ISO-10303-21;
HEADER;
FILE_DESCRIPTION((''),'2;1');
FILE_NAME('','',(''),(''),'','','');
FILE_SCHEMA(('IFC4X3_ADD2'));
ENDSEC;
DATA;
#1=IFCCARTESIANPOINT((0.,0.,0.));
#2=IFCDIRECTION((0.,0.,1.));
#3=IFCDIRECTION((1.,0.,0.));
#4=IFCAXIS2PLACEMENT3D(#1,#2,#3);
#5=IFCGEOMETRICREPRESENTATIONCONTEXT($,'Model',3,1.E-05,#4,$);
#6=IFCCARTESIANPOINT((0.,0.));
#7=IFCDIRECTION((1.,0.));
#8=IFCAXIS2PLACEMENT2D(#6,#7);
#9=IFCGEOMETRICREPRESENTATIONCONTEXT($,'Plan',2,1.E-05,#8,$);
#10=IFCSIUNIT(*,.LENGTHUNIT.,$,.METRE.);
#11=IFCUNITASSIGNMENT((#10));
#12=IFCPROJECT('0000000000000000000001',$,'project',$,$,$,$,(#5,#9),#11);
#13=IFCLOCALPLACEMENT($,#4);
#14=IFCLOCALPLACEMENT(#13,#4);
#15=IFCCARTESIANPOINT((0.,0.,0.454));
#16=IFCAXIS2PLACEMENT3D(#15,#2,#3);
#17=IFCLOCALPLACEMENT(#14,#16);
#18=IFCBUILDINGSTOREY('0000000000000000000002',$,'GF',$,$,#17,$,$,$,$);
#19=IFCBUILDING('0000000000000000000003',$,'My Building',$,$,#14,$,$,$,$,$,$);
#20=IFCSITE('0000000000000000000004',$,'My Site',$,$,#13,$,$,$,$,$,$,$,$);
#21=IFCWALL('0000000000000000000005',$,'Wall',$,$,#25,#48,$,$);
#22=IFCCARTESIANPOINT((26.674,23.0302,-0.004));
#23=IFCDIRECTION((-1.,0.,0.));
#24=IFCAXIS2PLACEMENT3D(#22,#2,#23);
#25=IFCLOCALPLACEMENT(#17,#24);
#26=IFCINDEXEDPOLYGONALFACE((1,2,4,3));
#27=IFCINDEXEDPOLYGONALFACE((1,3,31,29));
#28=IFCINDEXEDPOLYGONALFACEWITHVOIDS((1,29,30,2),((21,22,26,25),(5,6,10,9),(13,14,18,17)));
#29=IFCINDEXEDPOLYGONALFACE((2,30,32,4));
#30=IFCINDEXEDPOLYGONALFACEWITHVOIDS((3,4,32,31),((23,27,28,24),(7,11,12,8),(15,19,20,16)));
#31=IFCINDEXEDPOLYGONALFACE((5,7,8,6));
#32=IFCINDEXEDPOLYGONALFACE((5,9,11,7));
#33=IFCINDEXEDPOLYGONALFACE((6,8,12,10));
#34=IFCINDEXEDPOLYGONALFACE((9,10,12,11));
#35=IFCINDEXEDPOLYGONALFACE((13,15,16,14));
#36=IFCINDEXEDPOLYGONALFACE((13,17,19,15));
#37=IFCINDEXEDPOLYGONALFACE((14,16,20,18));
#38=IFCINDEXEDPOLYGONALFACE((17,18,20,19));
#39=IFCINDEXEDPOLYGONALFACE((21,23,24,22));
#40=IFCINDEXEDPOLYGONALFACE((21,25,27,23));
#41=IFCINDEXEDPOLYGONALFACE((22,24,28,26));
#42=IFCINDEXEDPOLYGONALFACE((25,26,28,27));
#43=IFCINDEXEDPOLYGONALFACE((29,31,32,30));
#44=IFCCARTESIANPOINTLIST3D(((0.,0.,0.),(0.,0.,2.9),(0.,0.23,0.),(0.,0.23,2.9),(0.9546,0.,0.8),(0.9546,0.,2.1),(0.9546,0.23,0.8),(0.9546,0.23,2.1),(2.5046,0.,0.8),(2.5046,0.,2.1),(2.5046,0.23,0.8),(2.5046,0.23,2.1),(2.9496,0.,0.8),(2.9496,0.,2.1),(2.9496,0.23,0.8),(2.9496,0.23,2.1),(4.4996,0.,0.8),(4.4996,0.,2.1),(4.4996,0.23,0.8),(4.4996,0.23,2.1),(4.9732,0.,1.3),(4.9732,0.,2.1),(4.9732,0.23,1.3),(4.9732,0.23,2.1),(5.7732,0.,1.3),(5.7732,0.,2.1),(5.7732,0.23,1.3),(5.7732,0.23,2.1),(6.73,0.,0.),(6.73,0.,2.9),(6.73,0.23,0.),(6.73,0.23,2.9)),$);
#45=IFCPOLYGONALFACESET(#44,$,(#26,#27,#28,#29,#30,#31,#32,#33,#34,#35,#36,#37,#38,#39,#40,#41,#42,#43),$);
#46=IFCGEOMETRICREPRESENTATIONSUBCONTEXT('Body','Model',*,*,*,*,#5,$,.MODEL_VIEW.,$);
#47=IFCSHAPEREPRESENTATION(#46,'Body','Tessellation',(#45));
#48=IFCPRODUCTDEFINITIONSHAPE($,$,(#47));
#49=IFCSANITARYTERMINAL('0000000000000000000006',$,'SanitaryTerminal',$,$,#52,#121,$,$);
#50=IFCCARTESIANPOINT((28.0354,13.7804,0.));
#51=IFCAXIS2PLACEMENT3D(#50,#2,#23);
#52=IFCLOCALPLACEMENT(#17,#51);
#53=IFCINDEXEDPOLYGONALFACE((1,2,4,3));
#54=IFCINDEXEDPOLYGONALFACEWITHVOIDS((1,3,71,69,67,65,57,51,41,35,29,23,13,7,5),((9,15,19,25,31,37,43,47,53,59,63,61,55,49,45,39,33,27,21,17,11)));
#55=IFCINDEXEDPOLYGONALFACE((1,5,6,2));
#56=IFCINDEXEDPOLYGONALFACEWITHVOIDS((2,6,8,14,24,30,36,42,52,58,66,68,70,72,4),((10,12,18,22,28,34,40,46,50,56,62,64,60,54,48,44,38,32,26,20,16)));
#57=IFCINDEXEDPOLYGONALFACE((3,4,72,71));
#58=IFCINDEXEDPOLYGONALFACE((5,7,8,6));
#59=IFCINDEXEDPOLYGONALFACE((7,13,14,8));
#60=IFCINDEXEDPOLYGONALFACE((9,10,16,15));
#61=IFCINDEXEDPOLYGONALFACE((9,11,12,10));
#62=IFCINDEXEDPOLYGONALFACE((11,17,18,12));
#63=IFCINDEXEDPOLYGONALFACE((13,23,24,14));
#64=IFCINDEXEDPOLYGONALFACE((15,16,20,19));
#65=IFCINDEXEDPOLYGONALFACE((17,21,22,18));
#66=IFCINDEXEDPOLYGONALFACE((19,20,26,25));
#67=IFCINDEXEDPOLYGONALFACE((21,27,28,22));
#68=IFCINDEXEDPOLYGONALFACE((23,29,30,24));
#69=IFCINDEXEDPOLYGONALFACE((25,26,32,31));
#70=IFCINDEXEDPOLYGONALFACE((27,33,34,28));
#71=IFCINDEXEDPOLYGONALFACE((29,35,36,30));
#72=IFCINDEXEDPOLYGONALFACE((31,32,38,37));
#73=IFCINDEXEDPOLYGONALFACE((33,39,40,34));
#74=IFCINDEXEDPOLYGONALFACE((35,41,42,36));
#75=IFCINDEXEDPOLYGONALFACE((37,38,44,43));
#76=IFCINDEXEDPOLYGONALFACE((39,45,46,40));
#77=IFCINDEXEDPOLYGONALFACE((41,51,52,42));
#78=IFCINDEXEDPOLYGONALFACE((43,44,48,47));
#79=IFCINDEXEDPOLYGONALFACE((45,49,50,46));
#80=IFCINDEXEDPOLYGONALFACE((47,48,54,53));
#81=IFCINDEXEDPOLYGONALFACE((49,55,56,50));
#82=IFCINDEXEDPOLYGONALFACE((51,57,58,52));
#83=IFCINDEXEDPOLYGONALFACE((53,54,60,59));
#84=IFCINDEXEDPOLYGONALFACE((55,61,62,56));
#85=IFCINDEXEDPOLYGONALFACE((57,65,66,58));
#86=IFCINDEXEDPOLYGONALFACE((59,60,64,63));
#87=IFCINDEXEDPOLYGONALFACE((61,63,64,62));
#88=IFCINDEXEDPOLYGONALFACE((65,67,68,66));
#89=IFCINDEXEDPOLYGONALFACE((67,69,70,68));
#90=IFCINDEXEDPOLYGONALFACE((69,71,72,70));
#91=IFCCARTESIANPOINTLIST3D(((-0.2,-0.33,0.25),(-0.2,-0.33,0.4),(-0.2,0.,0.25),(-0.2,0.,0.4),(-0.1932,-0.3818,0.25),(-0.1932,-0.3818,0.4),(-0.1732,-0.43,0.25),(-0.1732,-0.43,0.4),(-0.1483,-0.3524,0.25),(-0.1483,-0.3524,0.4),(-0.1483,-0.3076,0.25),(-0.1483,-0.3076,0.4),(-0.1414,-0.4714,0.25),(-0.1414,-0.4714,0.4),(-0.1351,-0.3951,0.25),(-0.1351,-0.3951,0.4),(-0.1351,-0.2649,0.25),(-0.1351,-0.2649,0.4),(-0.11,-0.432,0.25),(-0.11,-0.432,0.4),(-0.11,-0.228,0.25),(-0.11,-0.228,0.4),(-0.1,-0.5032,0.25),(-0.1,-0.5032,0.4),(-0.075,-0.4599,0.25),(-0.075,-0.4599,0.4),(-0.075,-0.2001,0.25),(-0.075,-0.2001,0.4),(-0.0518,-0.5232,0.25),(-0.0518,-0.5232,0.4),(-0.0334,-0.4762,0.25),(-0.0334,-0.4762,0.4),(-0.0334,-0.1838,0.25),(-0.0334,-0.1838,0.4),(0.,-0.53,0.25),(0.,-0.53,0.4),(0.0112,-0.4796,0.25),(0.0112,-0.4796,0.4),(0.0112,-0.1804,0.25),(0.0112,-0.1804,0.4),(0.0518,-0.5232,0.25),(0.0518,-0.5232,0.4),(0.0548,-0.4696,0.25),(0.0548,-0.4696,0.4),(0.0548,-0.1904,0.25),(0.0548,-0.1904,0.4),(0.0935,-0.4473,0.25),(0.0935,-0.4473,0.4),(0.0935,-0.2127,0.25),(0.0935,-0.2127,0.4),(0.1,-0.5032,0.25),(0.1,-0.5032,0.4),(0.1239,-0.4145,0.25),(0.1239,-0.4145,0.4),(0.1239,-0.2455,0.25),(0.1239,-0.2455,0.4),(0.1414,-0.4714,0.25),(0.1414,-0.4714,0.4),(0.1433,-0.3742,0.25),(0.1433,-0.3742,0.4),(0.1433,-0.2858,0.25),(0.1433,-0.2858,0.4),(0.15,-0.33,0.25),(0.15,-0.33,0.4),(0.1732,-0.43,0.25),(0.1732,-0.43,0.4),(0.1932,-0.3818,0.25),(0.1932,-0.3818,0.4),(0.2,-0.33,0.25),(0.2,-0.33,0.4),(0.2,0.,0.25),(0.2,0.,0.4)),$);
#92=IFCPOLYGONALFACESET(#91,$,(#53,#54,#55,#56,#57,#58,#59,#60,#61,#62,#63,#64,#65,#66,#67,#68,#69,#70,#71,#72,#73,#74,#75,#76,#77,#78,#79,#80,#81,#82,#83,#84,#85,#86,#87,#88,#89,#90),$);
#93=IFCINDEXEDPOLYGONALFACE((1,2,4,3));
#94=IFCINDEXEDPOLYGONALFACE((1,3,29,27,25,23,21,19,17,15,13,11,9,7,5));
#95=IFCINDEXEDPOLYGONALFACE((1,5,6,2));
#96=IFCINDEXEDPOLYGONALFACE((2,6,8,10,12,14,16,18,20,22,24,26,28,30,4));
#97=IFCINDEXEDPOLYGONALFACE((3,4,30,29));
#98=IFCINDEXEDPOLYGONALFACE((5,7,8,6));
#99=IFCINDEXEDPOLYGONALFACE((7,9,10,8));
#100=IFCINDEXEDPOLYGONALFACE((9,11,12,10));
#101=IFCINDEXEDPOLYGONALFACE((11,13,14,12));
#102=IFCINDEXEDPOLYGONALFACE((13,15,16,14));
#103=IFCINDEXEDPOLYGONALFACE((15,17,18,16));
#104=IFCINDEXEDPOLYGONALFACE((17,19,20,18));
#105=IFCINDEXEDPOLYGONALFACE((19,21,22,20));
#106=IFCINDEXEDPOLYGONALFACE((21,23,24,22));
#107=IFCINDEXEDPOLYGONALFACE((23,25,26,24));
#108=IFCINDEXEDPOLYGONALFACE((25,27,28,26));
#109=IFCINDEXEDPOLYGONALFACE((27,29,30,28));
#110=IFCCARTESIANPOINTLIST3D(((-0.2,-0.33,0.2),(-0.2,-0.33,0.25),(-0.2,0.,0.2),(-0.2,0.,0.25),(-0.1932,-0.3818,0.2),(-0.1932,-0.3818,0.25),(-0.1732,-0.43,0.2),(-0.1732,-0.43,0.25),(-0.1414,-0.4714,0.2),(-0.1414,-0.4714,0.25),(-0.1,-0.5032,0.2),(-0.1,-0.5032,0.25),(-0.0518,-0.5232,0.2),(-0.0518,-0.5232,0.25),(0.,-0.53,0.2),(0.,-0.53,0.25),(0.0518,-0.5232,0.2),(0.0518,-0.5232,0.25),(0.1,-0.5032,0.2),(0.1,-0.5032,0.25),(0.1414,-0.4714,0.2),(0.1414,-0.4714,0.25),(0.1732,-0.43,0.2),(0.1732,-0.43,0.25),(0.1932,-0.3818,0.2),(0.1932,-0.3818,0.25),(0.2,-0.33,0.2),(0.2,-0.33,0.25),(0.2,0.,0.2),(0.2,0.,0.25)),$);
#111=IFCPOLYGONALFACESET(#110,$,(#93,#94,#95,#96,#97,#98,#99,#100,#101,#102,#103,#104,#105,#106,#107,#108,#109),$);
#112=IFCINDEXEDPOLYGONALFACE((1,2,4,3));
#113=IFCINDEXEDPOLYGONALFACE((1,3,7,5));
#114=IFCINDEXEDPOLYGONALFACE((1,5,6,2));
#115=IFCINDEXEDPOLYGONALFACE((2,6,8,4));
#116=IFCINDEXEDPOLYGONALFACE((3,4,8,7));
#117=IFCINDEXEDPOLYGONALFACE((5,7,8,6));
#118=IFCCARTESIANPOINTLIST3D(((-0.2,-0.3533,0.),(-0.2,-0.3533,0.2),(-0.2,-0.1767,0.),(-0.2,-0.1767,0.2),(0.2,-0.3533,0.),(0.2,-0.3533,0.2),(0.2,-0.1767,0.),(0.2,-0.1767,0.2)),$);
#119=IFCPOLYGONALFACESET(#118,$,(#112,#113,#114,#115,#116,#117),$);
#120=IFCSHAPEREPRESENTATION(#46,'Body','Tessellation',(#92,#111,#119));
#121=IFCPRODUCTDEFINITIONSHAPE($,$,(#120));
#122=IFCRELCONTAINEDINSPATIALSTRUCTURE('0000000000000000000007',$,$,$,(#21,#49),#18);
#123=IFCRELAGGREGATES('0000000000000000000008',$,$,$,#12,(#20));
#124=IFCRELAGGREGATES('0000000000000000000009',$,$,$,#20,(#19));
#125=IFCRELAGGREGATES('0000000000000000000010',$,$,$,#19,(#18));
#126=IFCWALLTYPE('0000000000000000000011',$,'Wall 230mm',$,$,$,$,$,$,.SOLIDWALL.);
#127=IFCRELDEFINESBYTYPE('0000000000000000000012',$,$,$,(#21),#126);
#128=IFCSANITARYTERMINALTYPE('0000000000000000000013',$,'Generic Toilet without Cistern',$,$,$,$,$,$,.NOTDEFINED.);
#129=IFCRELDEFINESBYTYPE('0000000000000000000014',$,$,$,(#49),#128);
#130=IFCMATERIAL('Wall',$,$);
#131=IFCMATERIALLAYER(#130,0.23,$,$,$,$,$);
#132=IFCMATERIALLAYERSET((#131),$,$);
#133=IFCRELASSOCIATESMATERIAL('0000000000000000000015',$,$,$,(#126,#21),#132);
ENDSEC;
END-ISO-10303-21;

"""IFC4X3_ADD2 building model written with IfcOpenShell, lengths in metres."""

from ifc_helpers import new_model, entity, si_unit, frame, frame_2d, origin_with_axes, origin_2d_with_axis, place, context, subcontext, project, spatial, line, arc, indexed_curve, circle_curve, outline, extrude, shape, source, transform, mapped, material, layer, layer_set, layer_usage, type_object, type_shapes, element, save


model = new_model("IFC4X3_ADD2")

# Units and contexts
model_context = context("Model", 3, precision=1e-05, world=origin_with_axes())
plan_context = context("Plan", 2, precision=1e-05, world=origin_2d_with_axis())
body_context_1 = subcontext(model_context, "Body", "Model", "MODEL_VIEW")
body_context_2 = subcontext(plan_context, "Body", "Plan", "PLAN_VIEW")
ifc_project = project(units=[si_unit("LENGTHUNIT", "METRE")], contexts=[model_context, plan_context])

# Site, building, storey
site_placement = place(None, origin_with_axes())
site = spatial("IfcSite", under=ifc_project, at=site_placement, Name="My Site")
building_placement = place(site_placement, origin_with_axes())
building = spatial("IfcBuilding", under=site, at=building_placement, Name="My Building")
storey_placement = place(building_placement, frame((0.0, 0.0, 0.454), z_axis=(0.0, 0.0, 1.0), x_axis=(1.0, 0.0, 0.0)))
storey = spatial("IfcBuildingStorey", under=building, at=storey_placement, Name="GF")

# Shared definitions
ifc_material_1 = material(Name="Wall")

# Wall, openings
ifc_layer_1 = layer(ifc_material_1, 0.23)
ifc_layer_set_1 = layer_set([ifc_layer_1])
ifc_layer_usage_1 = layer_usage(ifc_layer_set_1, "AXIS2", "POSITIVE", 0.0)
wall_type_1 = type_object("IfcWallType", Name="Wall 230mm", PredefinedType="SOLIDWALL", material=ifc_layer_set_1)
wall_1_placement = place(storey_placement, frame((26.674, 23.0302, -0.004), z_axis=(0.0, 0.0, 1.0), x_axis=(-1.0, 0.0, 0.0)))
wall_1 = element("IfcWall", 1, at=wall_1_placement, inside=storey, type_object=wall_type_1, material=ifc_layer_usage_1, Name="Wall", context=body_context_1, shape_type="SweptSolid", body=[
    extrude(outline(indexed_curve([(0.0, 0.0), (0.0, 0.23), (6.73, 0.23), (6.73, 0.0), (0.0, 0.0)], self_intersect=False)), origin_with_axes(), (0.0, 0.0, 1.0), 2.9),
])
shared_shape_1 = source(origin_with_axes(), body_context_1, "Body", "SweptSolid", [
    extrude(outline(indexed_curve([(0.0, 0.0), (0.8, 0.0), (0.8, 0.8), (0.0, 0.8)], segments=[line(1, 2, 3, 4, 1)])), frame((-0.4, -0.6, 0.0), z_axis=(0.0, -1.0, 0.0), x_axis=(1.0, 0.0, 0.0)), (0.0, 0.0, -1.0), 1.2),
])
opening_1_placement = place(wall_1_placement, frame((5.3732, 0.16, 1.3), z_axis=(0.0, 0.0, 1.0), x_axis=(1.0, 0.0, 0.0)))
element("IfcOpeningElement", 2, at=opening_1_placement, cuts=wall_1, PredefinedType="OPENING", context=body_context_1, shape_type="MappedRepresentation", body=[
    mapped(shared_shape_1, transform((0.0, 0.0, 0.0), x_axis=(1.0, 0.0, 0.0), y_axis=(0.0, 1.0, 0.0), z_axis=(0.0, 0.0, 1.0), scale=1.0)),
])
shared_shape_2 = source(origin_with_axes(), body_context_1, "Body", "SweptSolid", [
    extrude(outline(indexed_curve([(0.0, 0.0), (1.55, 0.0), (1.55, 1.3), (0.0, 1.3)], segments=[line(1, 2, 3, 4, 1)])), frame((-0.775, -0.6, 0.0), z_axis=(0.0, -1.0, 0.0), x_axis=(1.0, 0.0, 0.0)), (0.0, 0.0, -1.0), 1.2),
])
opening_2_placement = place(wall_1_placement, frame((1.7296, 0.0, 0.8), z_axis=(0.0, 0.0, 1.0), x_axis=(1.0, 0.0, 0.0)))
element("IfcOpeningElement", 3, at=opening_2_placement, cuts=wall_1, PredefinedType="OPENING", context=body_context_1, shape_type="MappedRepresentation", body=[
    mapped(shared_shape_2, transform((0.0, 0.0, 0.0), x_axis=(1.0, 0.0, 0.0), y_axis=(0.0, 1.0, 0.0), z_axis=(0.0, 0.0, 1.0), scale=1.0)),
])
opening_3_placement = place(wall_1_placement, frame((3.7246, 0.0, 0.8), z_axis=(0.0, 0.0, 1.0), x_axis=(1.0, 0.0, 0.0)))
element("IfcOpeningElement", 4, at=opening_3_placement, cuts=wall_1, PredefinedType="OPENING", context=body_context_1, shape_type="MappedRepresentation", body=[
    mapped(shared_shape_2, transform((0.0, 0.0, 0.0), x_axis=(1.0, 0.0, 0.0), y_axis=(0.0, 1.0, 0.0), z_axis=(0.0, 0.0, 1.0), scale=1.0)),
])

# Sanitary terminal
sanitary_terminal_type_1 = type_object("IfcSanitaryTerminalType", Name="Generic Toilet without Cistern", PredefinedType="NOTDEFINED")
shared_shape_3 = source(origin_with_axes(), body_context_1, "Body", "SweptSolid", [
    extrude(outline(indexed_curve([(-0.2, 0.0), (0.2, 0.0), (0.2, -0.33), (0.1414, -0.4714), (0.0, -0.53), (-0.1414, -0.4714), (-0.2, -0.33)], segments=[line(1, 2), line(2, 3), arc(3, 4, 5), arc(5, 6, 7), line(7, 1)]), holes=[circle_curve(frame_2d((0.0, -0.33)), 0.15)]), frame((0.0, 0.0, 0.25), z_axis=(0.0, 0.0, 1.0), x_axis=(1.0, 0.0, 0.0)), (0.0, 0.0, 1.0), 0.15),
    extrude(outline(indexed_curve([(-0.2, 0.0), (0.2, 0.0), (0.2, -0.33), (0.1414, -0.4714), (0.0, -0.53), (-0.1414, -0.4714), (-0.2, -0.33)], segments=[line(1, 2), line(2, 3), arc(3, 4, 5), arc(5, 6, 7), line(7, 1)])), frame((0.0, 0.0, 0.2), z_axis=(0.0, 0.0, 1.0), x_axis=(1.0, 0.0, 0.0)), (0.0, 0.0, 1.0), 0.05),
    extrude(outline(indexed_curve([(-0.2, -0.1767), (0.2, -0.1767), (0.2, -0.3533), (-0.2, -0.3533)], segments=[line(1, 2, 3, 4, 1)])), origin_with_axes(), (0.0, 0.0, 1.0), 0.2),
])
shared_shape_4 = source(origin_with_axes(), body_context_2, "Body", "Annotation2D", [
    entity("IfcGeometricCurveSet", [entity("IfcIndexedPolyCurve", entity("IfcCartesianPointList2D", [[-0.1068, -0.124], [-0.0957, -0.1129], [-0.0804, -0.1088], [0.0804, -0.1088], [0.0957, -0.1129], [0.1068, -0.124], [0.1109, -0.1393], [0.1109, -0.3476], [0.1025, -0.3926], [0.0784, -0.4308], [0.0424, -0.4563], [0.0, -0.4652], [-0.0424, -0.4563], [-0.0784, -0.4308], [-0.1025, -0.3926], [-0.1109, -0.3476], [-0.1109, -0.1393]]), [entity("IfcLineIndex", [1, 2, 3, 4, 5, 6, 7, 8, 9, 10, 11, 12, 13, 14, 15, 16, 17, 1])]), entity("IfcIndexedPolyCurve", entity("IfcCartesianPointList2D", [[-0.1962, -0.2314], [-0.1848, -0.301], [-0.1764, -0.3339], [-0.1663, -0.3651], [-0.1546, -0.3944], [-0.1414, -0.4213], [-0.1269, -0.4458], [-0.1111, -0.4675], [-0.0943, -0.4862], [-0.0765, -0.5018], [-0.0581, -0.514], [-0.039, -0.5229], [-0.0196, -0.5282], [0.0, -0.53], [0.0196, -0.5282], [0.039, -0.5229], [0.0581, -0.514], [0.0765, -0.5018], [0.0943, -0.4862], [0.1111, -0.4675], [0.1269, -0.4458], [0.1414, -0.4213], [0.1546, -0.3944], [0.1663, -0.3651], [0.1764, -0.3339], [0.1848, -0.301], [0.1962, -0.2314], [0.2, -0.159], [0.1872, 0.0], [-0.1872, 0.0], [-0.2, -0.159]]), [entity("IfcLineIndex", [1, 2, 3, 4, 5, 6, 7, 8, 9, 10, 11, 12, 13, 14, 15, 16, 17, 18, 19, 20, 21, 22, 23, 24, 25, 26, 27, 28, 29, 30, 31, 1])])]),
])
type_shapes(sanitary_terminal_type_1, [shared_shape_3, shared_shape_4])
for number, where, z_axis, x_axis, name in (
    (5, (28.0354, 13.7804, 0.0), (0.0, 0.0, 1.0), (-1.0, 0.0, 0.0), "SanitaryTerminal"),
):
    element("IfcSanitaryTerminal", number, at=place(storey_placement, frame(where, z_axis=z_axis, x_axis=x_axis)), inside=storey, type_object=sanitary_terminal_type_1, Name=name, shapes=[
        shape(body_context_1, "Body", "MappedRepresentation", [mapped(shared_shape_3, transform((0.0, 0.0, 0.0), x_axis=(1.0, 0.0, 0.0), y_axis=(0.0, 1.0, 0.0), z_axis=(0.0, 0.0, 1.0), scale=1.0))]),
        shape(body_context_2, "Body", "MappedRepresentation", [mapped(shared_shape_4, transform((0.0, 0.0, 0.0), x_axis=(1.0, 0.0, 0.0), y_axis=(0.0, 1.0, 0.0), z_axis=(0.0, 0.0, 1.0), scale=1.0))]),
    ])

save(model, "model.ifc")
